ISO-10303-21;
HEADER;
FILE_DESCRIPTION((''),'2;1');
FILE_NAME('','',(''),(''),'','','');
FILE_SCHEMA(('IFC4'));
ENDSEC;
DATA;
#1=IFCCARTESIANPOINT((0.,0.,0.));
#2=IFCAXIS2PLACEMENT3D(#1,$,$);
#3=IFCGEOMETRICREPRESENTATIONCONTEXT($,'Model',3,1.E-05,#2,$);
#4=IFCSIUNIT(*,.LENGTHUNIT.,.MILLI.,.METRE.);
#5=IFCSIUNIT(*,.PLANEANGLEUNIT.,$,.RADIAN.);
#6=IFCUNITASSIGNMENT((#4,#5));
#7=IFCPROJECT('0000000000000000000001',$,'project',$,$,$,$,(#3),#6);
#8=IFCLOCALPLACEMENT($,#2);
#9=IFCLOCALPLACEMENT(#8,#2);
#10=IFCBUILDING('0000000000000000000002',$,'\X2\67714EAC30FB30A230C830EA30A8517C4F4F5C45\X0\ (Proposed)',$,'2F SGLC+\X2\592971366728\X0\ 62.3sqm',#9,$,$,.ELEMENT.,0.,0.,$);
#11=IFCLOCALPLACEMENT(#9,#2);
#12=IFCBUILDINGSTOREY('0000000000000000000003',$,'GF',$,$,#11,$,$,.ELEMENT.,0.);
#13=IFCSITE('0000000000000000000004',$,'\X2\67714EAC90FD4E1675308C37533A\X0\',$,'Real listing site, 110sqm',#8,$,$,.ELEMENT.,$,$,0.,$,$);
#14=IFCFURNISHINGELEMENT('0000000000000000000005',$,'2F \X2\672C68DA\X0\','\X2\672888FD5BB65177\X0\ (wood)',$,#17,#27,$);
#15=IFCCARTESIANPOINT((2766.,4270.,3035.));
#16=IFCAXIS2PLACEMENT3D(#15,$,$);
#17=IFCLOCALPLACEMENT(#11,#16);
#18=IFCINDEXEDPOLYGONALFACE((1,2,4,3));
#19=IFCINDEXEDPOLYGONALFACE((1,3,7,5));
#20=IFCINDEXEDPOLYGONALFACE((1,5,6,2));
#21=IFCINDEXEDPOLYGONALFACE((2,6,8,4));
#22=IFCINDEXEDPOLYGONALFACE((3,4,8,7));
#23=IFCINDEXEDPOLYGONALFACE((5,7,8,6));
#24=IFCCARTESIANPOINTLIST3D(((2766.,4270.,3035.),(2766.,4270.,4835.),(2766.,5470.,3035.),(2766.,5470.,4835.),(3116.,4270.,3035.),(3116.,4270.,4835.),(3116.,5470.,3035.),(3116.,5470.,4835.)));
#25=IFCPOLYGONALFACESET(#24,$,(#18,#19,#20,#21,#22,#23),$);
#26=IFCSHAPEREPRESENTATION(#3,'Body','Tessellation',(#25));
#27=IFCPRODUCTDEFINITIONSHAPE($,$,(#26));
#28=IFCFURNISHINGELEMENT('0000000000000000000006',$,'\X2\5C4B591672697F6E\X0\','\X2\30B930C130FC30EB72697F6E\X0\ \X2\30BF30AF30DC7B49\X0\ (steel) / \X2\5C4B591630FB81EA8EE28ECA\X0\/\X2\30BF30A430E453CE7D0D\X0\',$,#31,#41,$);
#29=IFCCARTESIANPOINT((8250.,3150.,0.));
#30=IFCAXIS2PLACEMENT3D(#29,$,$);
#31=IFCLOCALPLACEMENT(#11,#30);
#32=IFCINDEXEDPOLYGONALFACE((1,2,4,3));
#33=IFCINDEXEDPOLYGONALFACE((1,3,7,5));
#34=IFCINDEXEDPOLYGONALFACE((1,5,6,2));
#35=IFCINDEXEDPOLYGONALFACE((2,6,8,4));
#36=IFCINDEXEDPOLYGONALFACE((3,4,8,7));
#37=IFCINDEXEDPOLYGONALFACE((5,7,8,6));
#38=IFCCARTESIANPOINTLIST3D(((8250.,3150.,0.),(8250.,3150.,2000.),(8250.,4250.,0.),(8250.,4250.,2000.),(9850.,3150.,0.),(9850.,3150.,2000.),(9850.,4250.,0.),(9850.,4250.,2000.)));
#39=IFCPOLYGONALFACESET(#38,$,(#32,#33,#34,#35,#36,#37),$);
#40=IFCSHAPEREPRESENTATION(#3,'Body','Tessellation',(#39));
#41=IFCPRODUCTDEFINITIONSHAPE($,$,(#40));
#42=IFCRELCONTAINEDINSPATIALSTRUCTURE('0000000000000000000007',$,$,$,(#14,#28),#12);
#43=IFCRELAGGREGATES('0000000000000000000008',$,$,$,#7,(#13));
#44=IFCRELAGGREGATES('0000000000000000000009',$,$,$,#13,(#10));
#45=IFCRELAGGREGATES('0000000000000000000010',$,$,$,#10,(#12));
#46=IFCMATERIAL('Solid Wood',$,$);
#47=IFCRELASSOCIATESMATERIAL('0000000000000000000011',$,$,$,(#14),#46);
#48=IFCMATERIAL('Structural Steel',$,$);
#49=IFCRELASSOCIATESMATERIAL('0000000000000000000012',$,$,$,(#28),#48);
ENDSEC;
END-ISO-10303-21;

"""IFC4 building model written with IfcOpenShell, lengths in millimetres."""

from ifc_helpers import new_model, si_unit, frame, frame_2d, origin, place, context, project, spatial, rectangle, extrude, material, element, save


model = new_model("IFC4")

# Units and contexts
model_context = context("Model", 3, precision=1e-05, world=origin())
ifc_project = project(units=[si_unit("LENGTHUNIT", "METRE", prefix="MILLI"), si_unit("PLANEANGLEUNIT", "RADIAN")], contexts=[model_context])

# Site, building, storey
site_placement = place(None, origin())
site = spatial("IfcSite", under=ifc_project, at=site_placement, Name="東京都世田谷区", ObjectType="Real listing site, 110sqm", CompositionType="ELEMENT", RefElevation=0.0)
building_placement = place(site_placement, origin())
building = spatial("IfcBuilding", under=site, at=building_placement, Name="東京・アトリエ兼住居 (Proposed)", ObjectType="2F SGLC+天然木 62.3sqm", CompositionType="ELEMENT", ElevationOfRefHeight=0.0, ElevationOfTerrain=0.0)
storey_placement = place(building_placement, origin())
storey = spatial("IfcBuildingStorey", under=building, at=storey_placement, Name="GF", CompositionType="ELEMENT", Elevation=0.0)

# Shared definitions
ifc_material_1 = material(Name="Solid Wood")

# Shared definitions
ifc_material_2 = material(Name="Structural Steel")

# Furnishing elements
furnishing_1_placement = place(storey_placement, frame((2766.0, 4270.0, 3035.0)))
element("IfcFurnishingElement", 1, at=furnishing_1_placement, inside=storey, material=ifc_material_1, Name="2F 本棚", Description="木製家具 (wood)", context=model_context, shape_type="SweptSolid", body=[
    extrude(rectangle(XDim=350.0, YDim=1200.0, at=frame_2d((175.0, 600.0))), frame((2766.0, 4270.0, 3035.0)), (0.0, 0.0, 1.0), 1800.0),
])
furnishing_2_placement = place(storey_placement, frame((8250.0, 3150.0, 0.0)))
element("IfcFurnishingElement", 2, at=furnishing_2_placement, inside=storey, material=ifc_material_2, Name="屋外物置", Description="スチール物置 タクボ等 (steel) / 屋外・自転車/タイヤ収納", context=model_context, shape_type="SweptSolid", body=[
    extrude(rectangle(XDim=1600.0, YDim=1100.0, at=frame_2d((800.0, 550.0))), frame((8250.0, 3150.0, 0.0)), (0.0, 0.0, 1.0), 2000.0),
])

save(model, "model.ifc")
